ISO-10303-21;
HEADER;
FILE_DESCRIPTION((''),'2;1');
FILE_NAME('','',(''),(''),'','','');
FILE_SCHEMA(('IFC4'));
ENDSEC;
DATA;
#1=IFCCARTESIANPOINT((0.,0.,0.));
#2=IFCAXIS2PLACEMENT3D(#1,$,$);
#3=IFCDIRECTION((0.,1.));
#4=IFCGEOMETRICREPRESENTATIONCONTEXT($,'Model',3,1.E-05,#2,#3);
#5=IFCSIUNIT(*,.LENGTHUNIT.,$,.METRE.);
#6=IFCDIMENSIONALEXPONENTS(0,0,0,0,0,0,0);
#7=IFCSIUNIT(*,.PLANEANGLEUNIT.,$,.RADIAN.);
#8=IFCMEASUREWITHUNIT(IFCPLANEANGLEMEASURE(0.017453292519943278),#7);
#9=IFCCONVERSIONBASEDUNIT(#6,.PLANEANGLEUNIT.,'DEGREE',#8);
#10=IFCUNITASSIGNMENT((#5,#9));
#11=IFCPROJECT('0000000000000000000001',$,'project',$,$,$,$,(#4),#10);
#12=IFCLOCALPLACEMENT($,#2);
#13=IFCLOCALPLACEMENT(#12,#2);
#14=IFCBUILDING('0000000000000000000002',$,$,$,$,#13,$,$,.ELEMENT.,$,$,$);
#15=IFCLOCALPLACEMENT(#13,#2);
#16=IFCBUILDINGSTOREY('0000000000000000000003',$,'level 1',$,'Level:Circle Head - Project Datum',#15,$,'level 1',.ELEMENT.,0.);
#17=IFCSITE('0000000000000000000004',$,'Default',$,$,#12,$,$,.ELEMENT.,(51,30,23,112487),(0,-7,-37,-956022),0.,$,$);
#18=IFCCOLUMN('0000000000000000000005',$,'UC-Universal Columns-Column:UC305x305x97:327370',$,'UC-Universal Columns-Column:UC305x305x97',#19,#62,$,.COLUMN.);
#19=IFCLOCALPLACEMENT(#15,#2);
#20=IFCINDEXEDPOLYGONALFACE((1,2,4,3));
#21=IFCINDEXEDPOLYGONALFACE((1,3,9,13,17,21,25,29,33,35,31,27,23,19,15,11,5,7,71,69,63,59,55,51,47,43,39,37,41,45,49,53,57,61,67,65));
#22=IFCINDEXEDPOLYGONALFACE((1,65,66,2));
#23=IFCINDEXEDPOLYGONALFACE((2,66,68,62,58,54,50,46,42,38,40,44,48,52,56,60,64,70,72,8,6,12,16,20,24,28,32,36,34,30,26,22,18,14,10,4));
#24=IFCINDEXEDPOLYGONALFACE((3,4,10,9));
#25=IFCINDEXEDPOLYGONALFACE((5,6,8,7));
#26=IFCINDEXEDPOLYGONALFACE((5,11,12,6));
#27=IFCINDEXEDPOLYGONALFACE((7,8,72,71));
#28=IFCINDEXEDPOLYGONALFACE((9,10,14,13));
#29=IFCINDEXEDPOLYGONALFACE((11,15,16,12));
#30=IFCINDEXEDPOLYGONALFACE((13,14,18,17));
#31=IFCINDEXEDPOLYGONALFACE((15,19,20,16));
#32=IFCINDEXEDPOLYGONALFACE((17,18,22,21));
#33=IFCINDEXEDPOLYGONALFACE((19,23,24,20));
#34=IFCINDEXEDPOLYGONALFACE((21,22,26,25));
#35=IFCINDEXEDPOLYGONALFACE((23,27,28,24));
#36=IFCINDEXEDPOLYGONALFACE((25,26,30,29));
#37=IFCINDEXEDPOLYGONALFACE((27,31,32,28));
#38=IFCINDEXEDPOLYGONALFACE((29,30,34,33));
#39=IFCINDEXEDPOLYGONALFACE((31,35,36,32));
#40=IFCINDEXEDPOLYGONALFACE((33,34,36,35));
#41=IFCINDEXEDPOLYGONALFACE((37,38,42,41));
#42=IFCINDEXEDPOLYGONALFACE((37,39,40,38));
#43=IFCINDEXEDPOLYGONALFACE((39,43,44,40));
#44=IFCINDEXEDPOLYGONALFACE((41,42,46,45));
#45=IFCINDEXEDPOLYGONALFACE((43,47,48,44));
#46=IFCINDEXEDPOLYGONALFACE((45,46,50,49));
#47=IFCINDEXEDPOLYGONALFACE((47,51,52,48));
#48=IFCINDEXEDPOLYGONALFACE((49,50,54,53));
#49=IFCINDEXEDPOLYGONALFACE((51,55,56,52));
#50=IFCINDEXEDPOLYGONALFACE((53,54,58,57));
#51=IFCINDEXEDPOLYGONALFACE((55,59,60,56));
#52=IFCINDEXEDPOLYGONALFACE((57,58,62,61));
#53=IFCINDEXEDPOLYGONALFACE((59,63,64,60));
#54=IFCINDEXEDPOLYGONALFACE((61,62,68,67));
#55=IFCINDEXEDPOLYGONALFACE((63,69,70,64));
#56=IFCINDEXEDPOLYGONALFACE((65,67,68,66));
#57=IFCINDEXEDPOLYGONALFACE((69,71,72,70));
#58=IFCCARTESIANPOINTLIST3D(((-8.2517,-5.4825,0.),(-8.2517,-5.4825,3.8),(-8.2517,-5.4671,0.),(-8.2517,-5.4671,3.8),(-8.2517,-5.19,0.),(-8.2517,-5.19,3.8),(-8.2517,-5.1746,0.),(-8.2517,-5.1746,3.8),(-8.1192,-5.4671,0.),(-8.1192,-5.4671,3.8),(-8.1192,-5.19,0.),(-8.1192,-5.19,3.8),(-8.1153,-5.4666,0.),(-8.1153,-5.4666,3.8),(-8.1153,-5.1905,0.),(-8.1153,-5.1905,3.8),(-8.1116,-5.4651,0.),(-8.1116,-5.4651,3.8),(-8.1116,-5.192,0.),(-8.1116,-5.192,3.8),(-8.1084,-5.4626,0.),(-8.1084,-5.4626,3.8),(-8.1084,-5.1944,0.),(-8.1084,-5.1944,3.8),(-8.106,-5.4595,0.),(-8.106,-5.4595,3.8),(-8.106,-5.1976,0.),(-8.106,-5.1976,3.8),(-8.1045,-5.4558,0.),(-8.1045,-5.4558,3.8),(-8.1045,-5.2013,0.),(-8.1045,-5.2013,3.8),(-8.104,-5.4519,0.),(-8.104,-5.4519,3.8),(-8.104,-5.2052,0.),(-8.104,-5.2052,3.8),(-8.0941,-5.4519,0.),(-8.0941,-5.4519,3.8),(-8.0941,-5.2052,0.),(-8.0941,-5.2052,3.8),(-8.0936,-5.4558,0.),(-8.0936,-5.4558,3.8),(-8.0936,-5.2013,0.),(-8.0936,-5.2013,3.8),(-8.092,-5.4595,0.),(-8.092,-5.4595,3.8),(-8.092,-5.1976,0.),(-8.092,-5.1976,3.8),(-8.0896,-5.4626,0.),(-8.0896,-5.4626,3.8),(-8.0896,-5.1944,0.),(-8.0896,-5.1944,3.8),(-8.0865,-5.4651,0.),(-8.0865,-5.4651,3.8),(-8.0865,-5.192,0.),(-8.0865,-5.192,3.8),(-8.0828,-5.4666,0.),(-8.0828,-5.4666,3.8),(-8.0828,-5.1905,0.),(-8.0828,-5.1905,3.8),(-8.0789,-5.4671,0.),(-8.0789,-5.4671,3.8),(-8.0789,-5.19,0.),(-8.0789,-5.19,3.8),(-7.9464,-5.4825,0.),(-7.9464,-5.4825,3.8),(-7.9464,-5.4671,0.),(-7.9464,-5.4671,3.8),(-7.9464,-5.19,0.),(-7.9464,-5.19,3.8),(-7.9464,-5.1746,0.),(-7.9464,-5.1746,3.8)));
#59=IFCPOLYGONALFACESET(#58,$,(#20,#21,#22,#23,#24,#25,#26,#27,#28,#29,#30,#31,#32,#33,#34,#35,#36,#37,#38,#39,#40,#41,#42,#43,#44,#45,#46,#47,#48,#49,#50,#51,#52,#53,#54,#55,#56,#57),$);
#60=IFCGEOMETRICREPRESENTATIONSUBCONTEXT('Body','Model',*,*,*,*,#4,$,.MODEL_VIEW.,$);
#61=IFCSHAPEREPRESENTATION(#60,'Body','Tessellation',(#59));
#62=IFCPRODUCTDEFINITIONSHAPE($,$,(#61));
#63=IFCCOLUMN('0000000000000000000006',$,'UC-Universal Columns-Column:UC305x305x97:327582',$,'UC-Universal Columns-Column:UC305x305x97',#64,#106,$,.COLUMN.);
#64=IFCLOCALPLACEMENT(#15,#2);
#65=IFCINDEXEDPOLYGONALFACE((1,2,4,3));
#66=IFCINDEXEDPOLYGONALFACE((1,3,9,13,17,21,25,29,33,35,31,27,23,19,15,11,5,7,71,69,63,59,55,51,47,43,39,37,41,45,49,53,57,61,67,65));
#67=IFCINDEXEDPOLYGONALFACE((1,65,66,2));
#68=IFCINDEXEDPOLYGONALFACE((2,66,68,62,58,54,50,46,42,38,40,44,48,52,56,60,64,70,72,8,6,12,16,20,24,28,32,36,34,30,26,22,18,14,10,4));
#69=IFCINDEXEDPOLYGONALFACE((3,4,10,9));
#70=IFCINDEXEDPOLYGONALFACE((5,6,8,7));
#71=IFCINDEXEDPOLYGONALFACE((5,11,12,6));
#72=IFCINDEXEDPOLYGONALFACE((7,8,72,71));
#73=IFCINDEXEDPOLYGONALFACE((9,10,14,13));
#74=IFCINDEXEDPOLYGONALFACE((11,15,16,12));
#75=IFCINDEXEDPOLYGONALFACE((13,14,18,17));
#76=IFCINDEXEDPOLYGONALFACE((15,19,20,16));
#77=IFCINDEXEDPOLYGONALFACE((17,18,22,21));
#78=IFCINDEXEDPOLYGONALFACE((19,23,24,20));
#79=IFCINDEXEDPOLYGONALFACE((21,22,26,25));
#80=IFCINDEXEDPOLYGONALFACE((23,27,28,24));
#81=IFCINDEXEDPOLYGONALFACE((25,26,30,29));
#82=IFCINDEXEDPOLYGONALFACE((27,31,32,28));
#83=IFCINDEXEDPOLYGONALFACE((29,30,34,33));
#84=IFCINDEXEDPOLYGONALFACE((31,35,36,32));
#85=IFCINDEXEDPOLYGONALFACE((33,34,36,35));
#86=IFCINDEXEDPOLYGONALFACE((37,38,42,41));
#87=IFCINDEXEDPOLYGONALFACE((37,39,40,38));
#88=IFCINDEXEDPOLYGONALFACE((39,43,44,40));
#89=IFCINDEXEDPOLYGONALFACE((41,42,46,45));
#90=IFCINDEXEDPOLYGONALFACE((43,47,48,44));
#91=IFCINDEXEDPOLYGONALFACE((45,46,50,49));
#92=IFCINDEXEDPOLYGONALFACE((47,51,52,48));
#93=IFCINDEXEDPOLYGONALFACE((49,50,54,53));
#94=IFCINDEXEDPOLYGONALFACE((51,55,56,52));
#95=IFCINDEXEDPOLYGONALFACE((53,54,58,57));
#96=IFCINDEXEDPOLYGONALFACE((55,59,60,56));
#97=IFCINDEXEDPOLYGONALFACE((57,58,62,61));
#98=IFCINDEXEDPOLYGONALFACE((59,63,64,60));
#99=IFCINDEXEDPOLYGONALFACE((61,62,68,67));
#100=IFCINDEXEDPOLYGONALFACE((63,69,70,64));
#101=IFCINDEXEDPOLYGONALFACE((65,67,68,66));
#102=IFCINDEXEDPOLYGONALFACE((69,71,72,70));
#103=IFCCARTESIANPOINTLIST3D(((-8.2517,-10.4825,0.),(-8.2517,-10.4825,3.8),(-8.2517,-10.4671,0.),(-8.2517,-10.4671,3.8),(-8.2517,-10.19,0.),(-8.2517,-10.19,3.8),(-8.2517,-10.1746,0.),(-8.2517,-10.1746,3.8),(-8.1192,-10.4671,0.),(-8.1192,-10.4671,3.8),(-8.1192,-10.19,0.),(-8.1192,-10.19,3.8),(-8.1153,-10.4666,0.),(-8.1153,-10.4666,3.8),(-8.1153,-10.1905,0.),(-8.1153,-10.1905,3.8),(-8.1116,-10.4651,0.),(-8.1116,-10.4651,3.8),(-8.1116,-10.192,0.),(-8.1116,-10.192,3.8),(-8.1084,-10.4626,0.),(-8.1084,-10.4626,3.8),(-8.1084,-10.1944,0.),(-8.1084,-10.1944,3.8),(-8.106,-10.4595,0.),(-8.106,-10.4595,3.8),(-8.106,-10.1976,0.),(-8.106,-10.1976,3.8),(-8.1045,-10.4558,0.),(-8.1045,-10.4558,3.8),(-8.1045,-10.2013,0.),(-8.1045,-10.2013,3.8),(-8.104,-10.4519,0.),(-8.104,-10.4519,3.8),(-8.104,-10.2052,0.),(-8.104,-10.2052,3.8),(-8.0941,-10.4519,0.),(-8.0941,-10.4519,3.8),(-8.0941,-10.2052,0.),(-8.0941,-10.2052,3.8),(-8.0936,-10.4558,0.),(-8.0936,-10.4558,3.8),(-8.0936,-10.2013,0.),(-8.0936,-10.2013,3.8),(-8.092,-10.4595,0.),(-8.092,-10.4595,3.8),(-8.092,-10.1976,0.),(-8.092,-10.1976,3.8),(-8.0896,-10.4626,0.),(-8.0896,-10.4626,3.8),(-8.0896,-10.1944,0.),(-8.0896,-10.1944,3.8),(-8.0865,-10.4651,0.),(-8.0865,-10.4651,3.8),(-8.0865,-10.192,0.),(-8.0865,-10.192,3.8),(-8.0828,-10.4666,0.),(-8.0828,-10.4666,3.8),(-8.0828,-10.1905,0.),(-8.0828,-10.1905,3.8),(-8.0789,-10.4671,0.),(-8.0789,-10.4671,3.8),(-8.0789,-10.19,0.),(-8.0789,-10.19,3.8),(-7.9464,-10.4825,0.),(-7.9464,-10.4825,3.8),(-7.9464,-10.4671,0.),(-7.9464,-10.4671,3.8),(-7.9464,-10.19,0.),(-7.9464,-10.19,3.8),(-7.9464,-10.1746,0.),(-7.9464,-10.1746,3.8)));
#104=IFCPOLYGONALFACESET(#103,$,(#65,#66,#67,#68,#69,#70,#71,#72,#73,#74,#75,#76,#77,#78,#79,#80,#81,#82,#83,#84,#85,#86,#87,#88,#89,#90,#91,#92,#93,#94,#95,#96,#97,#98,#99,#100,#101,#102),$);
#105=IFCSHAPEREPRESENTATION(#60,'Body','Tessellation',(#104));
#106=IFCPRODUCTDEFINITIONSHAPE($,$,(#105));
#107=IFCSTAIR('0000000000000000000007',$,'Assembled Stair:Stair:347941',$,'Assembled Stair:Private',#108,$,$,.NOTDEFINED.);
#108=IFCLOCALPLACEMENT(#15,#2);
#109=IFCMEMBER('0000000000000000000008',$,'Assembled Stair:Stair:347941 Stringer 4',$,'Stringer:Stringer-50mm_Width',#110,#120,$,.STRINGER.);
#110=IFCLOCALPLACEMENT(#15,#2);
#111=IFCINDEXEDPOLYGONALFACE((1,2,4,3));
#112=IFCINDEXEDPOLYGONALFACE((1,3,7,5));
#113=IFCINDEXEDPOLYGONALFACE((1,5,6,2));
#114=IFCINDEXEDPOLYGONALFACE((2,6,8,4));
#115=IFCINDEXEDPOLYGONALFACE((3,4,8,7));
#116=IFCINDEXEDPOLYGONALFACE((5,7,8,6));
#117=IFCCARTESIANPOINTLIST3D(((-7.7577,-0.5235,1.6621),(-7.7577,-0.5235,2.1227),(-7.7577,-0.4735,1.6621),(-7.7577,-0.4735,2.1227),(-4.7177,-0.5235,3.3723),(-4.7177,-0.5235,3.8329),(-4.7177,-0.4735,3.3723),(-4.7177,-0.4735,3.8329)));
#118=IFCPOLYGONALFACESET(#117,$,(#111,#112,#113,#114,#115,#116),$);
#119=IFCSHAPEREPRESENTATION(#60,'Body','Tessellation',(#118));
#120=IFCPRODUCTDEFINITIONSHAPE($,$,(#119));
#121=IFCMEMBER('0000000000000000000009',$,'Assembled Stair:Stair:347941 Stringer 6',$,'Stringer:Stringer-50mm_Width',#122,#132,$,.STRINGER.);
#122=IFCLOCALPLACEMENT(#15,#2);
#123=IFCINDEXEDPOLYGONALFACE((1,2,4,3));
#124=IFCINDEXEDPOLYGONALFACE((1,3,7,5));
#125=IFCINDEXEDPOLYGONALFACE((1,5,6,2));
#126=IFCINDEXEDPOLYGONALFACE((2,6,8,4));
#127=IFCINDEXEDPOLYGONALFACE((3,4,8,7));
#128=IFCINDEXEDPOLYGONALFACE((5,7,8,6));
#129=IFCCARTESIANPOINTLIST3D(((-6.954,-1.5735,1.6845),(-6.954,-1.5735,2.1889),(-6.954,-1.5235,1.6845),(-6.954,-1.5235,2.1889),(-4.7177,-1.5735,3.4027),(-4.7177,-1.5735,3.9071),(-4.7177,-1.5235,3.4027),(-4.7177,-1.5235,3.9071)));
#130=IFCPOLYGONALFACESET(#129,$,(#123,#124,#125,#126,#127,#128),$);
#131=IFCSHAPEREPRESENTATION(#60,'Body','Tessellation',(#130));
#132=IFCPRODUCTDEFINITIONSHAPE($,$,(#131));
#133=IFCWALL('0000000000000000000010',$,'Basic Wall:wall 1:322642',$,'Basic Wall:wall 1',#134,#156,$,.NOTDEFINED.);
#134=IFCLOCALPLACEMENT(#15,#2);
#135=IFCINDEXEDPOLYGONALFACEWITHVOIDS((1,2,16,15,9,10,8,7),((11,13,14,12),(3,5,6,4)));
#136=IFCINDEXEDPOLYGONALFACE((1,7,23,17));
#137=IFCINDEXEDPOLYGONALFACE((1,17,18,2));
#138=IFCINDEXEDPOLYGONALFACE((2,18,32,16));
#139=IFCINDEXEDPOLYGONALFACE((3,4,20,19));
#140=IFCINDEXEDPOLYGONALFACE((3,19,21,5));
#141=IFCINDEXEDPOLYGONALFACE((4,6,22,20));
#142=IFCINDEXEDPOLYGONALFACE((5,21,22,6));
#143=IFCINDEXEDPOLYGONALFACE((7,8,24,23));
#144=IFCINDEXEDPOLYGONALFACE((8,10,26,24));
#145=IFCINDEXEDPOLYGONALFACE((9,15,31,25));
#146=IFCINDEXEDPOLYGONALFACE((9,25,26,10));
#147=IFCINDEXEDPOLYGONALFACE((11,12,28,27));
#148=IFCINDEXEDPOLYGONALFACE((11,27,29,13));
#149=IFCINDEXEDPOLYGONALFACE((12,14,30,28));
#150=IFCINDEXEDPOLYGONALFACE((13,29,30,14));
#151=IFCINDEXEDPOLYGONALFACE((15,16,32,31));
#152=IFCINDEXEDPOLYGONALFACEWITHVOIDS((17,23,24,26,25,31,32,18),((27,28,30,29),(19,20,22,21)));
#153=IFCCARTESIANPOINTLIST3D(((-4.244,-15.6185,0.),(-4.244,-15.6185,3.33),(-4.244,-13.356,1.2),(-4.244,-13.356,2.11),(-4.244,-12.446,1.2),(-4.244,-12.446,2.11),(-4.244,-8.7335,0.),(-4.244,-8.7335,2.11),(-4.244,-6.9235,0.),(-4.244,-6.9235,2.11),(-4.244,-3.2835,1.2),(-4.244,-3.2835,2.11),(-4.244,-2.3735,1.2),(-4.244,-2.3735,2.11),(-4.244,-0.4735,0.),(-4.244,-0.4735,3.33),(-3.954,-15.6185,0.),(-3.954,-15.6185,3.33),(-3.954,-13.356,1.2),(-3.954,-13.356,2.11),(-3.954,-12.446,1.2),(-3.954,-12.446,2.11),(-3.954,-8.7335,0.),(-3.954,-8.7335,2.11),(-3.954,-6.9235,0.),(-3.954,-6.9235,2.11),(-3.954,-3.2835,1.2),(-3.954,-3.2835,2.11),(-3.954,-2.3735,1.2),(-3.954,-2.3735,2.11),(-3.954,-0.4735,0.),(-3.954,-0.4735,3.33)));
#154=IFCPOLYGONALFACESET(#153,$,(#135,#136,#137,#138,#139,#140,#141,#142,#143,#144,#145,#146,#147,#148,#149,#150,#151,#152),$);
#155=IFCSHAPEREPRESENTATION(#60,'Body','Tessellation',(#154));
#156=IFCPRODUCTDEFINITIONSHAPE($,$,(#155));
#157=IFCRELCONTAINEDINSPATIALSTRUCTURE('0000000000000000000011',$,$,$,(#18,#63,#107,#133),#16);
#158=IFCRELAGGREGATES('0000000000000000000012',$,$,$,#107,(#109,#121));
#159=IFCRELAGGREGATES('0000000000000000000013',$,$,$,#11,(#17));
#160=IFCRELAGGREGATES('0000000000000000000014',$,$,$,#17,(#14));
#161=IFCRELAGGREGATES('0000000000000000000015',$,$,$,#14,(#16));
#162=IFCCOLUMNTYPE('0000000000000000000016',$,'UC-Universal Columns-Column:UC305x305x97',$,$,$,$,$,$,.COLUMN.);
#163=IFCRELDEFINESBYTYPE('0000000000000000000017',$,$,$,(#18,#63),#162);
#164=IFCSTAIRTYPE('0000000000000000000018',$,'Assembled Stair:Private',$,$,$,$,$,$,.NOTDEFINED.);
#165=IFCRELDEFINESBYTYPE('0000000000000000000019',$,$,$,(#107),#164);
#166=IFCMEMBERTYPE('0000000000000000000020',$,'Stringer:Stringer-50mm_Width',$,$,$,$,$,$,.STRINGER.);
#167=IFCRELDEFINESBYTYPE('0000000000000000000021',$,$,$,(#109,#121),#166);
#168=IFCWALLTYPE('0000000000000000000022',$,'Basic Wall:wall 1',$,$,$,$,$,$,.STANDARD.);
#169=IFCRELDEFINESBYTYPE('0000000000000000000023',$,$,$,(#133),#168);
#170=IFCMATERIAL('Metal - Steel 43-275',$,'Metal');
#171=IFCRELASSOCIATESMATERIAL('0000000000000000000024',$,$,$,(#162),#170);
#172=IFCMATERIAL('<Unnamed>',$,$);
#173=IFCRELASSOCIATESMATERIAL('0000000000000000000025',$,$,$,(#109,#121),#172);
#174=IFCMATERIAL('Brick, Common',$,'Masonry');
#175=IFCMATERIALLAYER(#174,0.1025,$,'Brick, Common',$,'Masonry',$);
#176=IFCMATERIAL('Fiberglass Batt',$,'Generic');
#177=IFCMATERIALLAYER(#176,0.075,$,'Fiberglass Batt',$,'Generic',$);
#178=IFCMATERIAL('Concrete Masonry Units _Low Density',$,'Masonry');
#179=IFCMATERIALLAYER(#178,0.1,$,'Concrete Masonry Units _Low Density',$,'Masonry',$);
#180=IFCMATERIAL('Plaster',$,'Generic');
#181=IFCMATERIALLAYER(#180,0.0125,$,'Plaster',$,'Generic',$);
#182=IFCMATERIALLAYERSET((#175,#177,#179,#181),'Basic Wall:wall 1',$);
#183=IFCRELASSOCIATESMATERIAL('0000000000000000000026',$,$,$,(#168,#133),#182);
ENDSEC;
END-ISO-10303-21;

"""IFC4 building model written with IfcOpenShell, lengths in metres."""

from ifc_helpers import new_model, entity, si_unit, converted_unit, direction, frame, frame_2d, origin, origin_2d_with_axis, place, context, subcontext, project, spatial, polyline, rectangle, i_section, outline, extrude, clip, bounded_halfspace, source, transform, mapped, material, layer, layer_set, layer_usage, material_profile, profile_set, type_object, type_shapes, element, aggregate, save


model = new_model("IFC4")

# Units and contexts
model_context = context("Model", 3, precision=1e-05, world=origin(), true_north=direction((0.0, 1.0)))
body_context = subcontext(model_context, "Body", "Model", "MODEL_VIEW")
ifc_project = project(units=[si_unit("LENGTHUNIT", "METRE"), converted_unit("PLANEANGLEUNIT", "DEGREE", entity("IfcPlaneAngleMeasure", 0.017453292519943278), si_unit("PLANEANGLEUNIT", "RADIAN"), dimensions=[0, 0, 0, 0, 0, 0, 0])], contexts=[model_context])

# Site, building, storey
site_placement = place(None, origin())
site = spatial("IfcSite", under=ifc_project, at=site_placement, Name="Default", CompositionType="ELEMENT", RefLatitude=(51, 30, 23, 112487), RefLongitude=(0, -7, -37, -956022), RefElevation=0.0)
building_placement = place(site_placement, origin())
building = spatial("IfcBuilding", under=site, at=building_placement, CompositionType="ELEMENT")
storey_placement = place(building_placement, origin())
storey = spatial("IfcBuildingStorey", under=building, at=storey_placement, Name="level 1", ObjectType="Level:Circle Head - Project Datum", LongName="level 1", CompositionType="ELEMENT", Elevation=0.0)

# Columns
ifc_material_1 = material(Name="Metal - Steel 43-275", Category="Metal")
ifc_material_profile = material_profile(ifc_material_1, i_section(OverallWidth=0.3053, OverallDepth=0.3079, WebThickness=0.0099, FlangeThickness=0.0154, FilletRadius=0.0152, at=frame_2d((0.0, 0.0), x_axis=(1.0, 0.0))), Name="UC305x305x97")
ifc_profile_set = profile_set([ifc_material_profile], Name="UC305x305x97")
column_type = type_object("IfcColumnType", Name="UC-Universal Columns-Column:UC305x305x97", PredefinedType="COLUMN", material=ifc_profile_set)
shared_shape = source(origin(), body_context, "Body", "SweptSolid", [
    extrude(i_section(OverallWidth=0.3053, OverallDepth=0.3079, WebThickness=0.0099, FlangeThickness=0.0154, FilletRadius=0.0152, at=origin_2d_with_axis()), frame((0.0, 0.0, 0.0), z_axis=(0.0, 0.0, 1.0), x_axis=(-1.0, 0.0, 0.0)), (0.0, 0.0, 1.0), 3.8),
])
type_shapes(column_type, [shared_shape])
for number, where, name in (
    (1, (-8.099, -5.3285, 0.0), "UC-Universal Columns-Column:UC305x305x97:327370"),
    (2, (-8.099, -10.3285, 0.0), "UC-Universal Columns-Column:UC305x305x97:327582"),
):
    element("IfcColumn", number, at=place(storey_placement, frame(where)), inside=storey, type_object=column_type, Name=name, ObjectType="UC-Universal Columns-Column:UC305x305x97", PredefinedType="COLUMN", context=body_context, shape_type="MappedRepresentation", body=[
        mapped(shared_shape, transform((0.0, 0.0, 0.0), scale=1.0)),
    ])

# Stair, members
stair_type = type_object("IfcStairType", Name="Assembled Stair:Private", PredefinedType="NOTDEFINED")
stair_placement = place(storey_placement, origin())
stair = element("IfcStair", 3, at=stair_placement, inside=storey, type_object=stair_type, Name="Assembled Stair:Stair:347941", ObjectType="Assembled Stair:Private", PredefinedType="NOTDEFINED")
ifc_material_2 = material(Name="<Unnamed>")
member_type = type_object("IfcMemberType", Name="Stringer:Stringer-50mm_Width", PredefinedType="STRINGER")
member_1_placement = place(stair_placement, frame((-7.7577, -0.5235, 1.6621)))
member_1 = element("IfcMember", 4, at=member_1_placement, type_object=member_type, material=ifc_material_2, Name="Assembled Stair:Stair:347941 Stringer 4", ObjectType="Stringer:Stringer-50mm_Width", PredefinedType="STRINGER", context=body_context, shape_type="SweptSolid", body=[
    extrude(outline(polyline([(-1.6311, -0.2007), (1.857, -0.2007), (1.6311, 0.2007), (-1.857, 0.2007), (-1.6311, -0.2007)])), frame((1.52, 0.0, 1.0854), z_axis=(0.0, 1.0, 0.0), x_axis=(0.871553, 0.0, 0.490302)), (0.0, 0.0, 1.0), 0.05),
])
member_2_placement = place(stair_placement, frame((-6.954, -1.5735, 1.6845)))
member_2 = element("IfcMember", 5, at=member_2_placement, type_object=member_type, material=ifc_material_2, Name="Assembled Stair:Stair:347941 Stringer 6", ObjectType="Stringer:Stringer-50mm_Width", PredefinedType="STRINGER", context=body_context, shape_type="SweptSolid", body=[
    extrude(outline(polyline([(-1.2564, -0.2), (1.5637, -0.2), (1.2564, 0.2), (-1.5637, 0.2), (-1.2564, -0.2)])), frame((1.1182, 0.0, 1.1113), z_axis=(0.0, 1.0, 0.0), x_axis=(0.792984, 0.0, 0.609242)), (0.0, 0.0, 1.0), 0.05),
])
aggregate(stair, [member_1, member_2])

# Wall, openings
ifc_material_3 = material(Name="Brick, Common", Category="Masonry")
ifc_layer_1 = layer(ifc_material_3, 0.1025, Name="Brick, Common", Category="Masonry")
ifc_material_4 = material(Name="Fiberglass Batt", Category="Generic")
ifc_layer_2 = layer(ifc_material_4, 0.075, Name="Fiberglass Batt", Category="Generic")
ifc_material_5 = material(Name="Concrete Masonry Units _Low Density", Category="Masonry")
ifc_layer_3 = layer(ifc_material_5, 0.1, Name="Concrete Masonry Units _Low Density", Category="Masonry")
ifc_material_6 = material(Name="Plaster", Category="Generic")
ifc_layer_4 = layer(ifc_material_6, 0.0125, Name="Plaster", Category="Generic")
ifc_layer_set_1 = layer_set([ifc_layer_1, ifc_layer_2, ifc_layer_3, ifc_layer_4], Name="Basic Wall:wall 1")
ifc_layer_usage_1 = layer_usage(ifc_layer_set_1, "AXIS2", "NEGATIVE", 0.145)
wall_type_1 = type_object("IfcWallType", Name="Basic Wall:wall 1", PredefinedType="STANDARD", material=ifc_layer_set_1)
wall_1_placement = place(storey_placement, frame((-4.099, -0.4735, 0.0), z_axis=(0.0, 0.0, 1.0), x_axis=(0.0, -1.0, 0.0)))
wall_1 = element("IfcWall", 6, at=wall_1_placement, inside=storey, type_object=wall_type_1, material=ifc_layer_usage_1, Name="Basic Wall:wall 1:322642", ObjectType="Basic Wall:wall 1", PredefinedType="NOTDEFINED", context=body_context, shape_type="Clipping", body=[
    clip(extrude(rectangle(XDim=15.145, YDim=0.29, at=frame_2d((7.5725, 0.0), x_axis=(-1.0, 0.0))), origin(), (0.0, 0.0, 1.0), 3.33), bounded_halfspace(frame((0.0, -0.145, 3.33), z_axis=(0.0, 0.0, -1.0), x_axis=(-1.0, 0.0, 0.0)), True, frame((0.0, -0.145, 3.33)), polyline([(0.0, 0.0), (4.7925, 0.0), (4.9175, 0.0), (9.7925, 0.0), (9.9175, 0.0), (14.855, 0.0), (15.145, 0.0), (15.145, 0.29), (0.0, 0.29), (0.0, 0.2806), (0.0, 0.0)]))),
])
opening_1_placement = place(wall_1_placement, frame((8.26, 0.145, 0.0)))
element("IfcOpeningElement", 7, at=opening_1_placement, cuts=wall_1, PredefinedType="OPENING", context=body_context, shape_type="SweptSolid", body=[
    extrude(rectangle(XDim=2.11, YDim=1.81, at=frame_2d((1.055, 0.905), x_axis=(-1.0, 0.0))), frame((0.0, 0.0, 0.0), z_axis=(0.0, -1.0, 0.0), x_axis=(0.0, 0.0, 1.0)), (0.0, 0.0, 1.0), 0.29),
])
opening_2_placement = place(wall_1_placement, frame((11.9725, -0.145, 1.2)))
element("IfcOpeningElement", 8, at=opening_2_placement, cuts=wall_1, PredefinedType="OPENING", context=body_context, shape_type="SweptSolid", body=[
    extrude(rectangle(XDim=0.91, YDim=0.91, at=frame_2d((0.455, 0.455), x_axis=(-1.0, 0.0))), frame((0.0, 0.0, 0.0), z_axis=(0.0, 1.0, 0.0), x_axis=(0.0, 0.0, 1.0)), (0.0, 0.0, 1.0), 0.29),
])
opening_3_placement = place(wall_1_placement, frame((1.9, -0.145, 1.2)))
element("IfcOpeningElement", 9, at=opening_3_placement, cuts=wall_1, PredefinedType="OPENING", context=body_context, shape_type="SweptSolid", body=[
    extrude(rectangle(XDim=0.91, YDim=0.91, at=frame_2d((0.455, 0.455), x_axis=(-1.0, 0.0))), frame((0.0, 0.0, 0.0), z_axis=(0.0, 1.0, 0.0), x_axis=(0.0, 0.0, 1.0)), (0.0, 0.0, 1.0), 0.29),
])

save(model, "model.ifc")
